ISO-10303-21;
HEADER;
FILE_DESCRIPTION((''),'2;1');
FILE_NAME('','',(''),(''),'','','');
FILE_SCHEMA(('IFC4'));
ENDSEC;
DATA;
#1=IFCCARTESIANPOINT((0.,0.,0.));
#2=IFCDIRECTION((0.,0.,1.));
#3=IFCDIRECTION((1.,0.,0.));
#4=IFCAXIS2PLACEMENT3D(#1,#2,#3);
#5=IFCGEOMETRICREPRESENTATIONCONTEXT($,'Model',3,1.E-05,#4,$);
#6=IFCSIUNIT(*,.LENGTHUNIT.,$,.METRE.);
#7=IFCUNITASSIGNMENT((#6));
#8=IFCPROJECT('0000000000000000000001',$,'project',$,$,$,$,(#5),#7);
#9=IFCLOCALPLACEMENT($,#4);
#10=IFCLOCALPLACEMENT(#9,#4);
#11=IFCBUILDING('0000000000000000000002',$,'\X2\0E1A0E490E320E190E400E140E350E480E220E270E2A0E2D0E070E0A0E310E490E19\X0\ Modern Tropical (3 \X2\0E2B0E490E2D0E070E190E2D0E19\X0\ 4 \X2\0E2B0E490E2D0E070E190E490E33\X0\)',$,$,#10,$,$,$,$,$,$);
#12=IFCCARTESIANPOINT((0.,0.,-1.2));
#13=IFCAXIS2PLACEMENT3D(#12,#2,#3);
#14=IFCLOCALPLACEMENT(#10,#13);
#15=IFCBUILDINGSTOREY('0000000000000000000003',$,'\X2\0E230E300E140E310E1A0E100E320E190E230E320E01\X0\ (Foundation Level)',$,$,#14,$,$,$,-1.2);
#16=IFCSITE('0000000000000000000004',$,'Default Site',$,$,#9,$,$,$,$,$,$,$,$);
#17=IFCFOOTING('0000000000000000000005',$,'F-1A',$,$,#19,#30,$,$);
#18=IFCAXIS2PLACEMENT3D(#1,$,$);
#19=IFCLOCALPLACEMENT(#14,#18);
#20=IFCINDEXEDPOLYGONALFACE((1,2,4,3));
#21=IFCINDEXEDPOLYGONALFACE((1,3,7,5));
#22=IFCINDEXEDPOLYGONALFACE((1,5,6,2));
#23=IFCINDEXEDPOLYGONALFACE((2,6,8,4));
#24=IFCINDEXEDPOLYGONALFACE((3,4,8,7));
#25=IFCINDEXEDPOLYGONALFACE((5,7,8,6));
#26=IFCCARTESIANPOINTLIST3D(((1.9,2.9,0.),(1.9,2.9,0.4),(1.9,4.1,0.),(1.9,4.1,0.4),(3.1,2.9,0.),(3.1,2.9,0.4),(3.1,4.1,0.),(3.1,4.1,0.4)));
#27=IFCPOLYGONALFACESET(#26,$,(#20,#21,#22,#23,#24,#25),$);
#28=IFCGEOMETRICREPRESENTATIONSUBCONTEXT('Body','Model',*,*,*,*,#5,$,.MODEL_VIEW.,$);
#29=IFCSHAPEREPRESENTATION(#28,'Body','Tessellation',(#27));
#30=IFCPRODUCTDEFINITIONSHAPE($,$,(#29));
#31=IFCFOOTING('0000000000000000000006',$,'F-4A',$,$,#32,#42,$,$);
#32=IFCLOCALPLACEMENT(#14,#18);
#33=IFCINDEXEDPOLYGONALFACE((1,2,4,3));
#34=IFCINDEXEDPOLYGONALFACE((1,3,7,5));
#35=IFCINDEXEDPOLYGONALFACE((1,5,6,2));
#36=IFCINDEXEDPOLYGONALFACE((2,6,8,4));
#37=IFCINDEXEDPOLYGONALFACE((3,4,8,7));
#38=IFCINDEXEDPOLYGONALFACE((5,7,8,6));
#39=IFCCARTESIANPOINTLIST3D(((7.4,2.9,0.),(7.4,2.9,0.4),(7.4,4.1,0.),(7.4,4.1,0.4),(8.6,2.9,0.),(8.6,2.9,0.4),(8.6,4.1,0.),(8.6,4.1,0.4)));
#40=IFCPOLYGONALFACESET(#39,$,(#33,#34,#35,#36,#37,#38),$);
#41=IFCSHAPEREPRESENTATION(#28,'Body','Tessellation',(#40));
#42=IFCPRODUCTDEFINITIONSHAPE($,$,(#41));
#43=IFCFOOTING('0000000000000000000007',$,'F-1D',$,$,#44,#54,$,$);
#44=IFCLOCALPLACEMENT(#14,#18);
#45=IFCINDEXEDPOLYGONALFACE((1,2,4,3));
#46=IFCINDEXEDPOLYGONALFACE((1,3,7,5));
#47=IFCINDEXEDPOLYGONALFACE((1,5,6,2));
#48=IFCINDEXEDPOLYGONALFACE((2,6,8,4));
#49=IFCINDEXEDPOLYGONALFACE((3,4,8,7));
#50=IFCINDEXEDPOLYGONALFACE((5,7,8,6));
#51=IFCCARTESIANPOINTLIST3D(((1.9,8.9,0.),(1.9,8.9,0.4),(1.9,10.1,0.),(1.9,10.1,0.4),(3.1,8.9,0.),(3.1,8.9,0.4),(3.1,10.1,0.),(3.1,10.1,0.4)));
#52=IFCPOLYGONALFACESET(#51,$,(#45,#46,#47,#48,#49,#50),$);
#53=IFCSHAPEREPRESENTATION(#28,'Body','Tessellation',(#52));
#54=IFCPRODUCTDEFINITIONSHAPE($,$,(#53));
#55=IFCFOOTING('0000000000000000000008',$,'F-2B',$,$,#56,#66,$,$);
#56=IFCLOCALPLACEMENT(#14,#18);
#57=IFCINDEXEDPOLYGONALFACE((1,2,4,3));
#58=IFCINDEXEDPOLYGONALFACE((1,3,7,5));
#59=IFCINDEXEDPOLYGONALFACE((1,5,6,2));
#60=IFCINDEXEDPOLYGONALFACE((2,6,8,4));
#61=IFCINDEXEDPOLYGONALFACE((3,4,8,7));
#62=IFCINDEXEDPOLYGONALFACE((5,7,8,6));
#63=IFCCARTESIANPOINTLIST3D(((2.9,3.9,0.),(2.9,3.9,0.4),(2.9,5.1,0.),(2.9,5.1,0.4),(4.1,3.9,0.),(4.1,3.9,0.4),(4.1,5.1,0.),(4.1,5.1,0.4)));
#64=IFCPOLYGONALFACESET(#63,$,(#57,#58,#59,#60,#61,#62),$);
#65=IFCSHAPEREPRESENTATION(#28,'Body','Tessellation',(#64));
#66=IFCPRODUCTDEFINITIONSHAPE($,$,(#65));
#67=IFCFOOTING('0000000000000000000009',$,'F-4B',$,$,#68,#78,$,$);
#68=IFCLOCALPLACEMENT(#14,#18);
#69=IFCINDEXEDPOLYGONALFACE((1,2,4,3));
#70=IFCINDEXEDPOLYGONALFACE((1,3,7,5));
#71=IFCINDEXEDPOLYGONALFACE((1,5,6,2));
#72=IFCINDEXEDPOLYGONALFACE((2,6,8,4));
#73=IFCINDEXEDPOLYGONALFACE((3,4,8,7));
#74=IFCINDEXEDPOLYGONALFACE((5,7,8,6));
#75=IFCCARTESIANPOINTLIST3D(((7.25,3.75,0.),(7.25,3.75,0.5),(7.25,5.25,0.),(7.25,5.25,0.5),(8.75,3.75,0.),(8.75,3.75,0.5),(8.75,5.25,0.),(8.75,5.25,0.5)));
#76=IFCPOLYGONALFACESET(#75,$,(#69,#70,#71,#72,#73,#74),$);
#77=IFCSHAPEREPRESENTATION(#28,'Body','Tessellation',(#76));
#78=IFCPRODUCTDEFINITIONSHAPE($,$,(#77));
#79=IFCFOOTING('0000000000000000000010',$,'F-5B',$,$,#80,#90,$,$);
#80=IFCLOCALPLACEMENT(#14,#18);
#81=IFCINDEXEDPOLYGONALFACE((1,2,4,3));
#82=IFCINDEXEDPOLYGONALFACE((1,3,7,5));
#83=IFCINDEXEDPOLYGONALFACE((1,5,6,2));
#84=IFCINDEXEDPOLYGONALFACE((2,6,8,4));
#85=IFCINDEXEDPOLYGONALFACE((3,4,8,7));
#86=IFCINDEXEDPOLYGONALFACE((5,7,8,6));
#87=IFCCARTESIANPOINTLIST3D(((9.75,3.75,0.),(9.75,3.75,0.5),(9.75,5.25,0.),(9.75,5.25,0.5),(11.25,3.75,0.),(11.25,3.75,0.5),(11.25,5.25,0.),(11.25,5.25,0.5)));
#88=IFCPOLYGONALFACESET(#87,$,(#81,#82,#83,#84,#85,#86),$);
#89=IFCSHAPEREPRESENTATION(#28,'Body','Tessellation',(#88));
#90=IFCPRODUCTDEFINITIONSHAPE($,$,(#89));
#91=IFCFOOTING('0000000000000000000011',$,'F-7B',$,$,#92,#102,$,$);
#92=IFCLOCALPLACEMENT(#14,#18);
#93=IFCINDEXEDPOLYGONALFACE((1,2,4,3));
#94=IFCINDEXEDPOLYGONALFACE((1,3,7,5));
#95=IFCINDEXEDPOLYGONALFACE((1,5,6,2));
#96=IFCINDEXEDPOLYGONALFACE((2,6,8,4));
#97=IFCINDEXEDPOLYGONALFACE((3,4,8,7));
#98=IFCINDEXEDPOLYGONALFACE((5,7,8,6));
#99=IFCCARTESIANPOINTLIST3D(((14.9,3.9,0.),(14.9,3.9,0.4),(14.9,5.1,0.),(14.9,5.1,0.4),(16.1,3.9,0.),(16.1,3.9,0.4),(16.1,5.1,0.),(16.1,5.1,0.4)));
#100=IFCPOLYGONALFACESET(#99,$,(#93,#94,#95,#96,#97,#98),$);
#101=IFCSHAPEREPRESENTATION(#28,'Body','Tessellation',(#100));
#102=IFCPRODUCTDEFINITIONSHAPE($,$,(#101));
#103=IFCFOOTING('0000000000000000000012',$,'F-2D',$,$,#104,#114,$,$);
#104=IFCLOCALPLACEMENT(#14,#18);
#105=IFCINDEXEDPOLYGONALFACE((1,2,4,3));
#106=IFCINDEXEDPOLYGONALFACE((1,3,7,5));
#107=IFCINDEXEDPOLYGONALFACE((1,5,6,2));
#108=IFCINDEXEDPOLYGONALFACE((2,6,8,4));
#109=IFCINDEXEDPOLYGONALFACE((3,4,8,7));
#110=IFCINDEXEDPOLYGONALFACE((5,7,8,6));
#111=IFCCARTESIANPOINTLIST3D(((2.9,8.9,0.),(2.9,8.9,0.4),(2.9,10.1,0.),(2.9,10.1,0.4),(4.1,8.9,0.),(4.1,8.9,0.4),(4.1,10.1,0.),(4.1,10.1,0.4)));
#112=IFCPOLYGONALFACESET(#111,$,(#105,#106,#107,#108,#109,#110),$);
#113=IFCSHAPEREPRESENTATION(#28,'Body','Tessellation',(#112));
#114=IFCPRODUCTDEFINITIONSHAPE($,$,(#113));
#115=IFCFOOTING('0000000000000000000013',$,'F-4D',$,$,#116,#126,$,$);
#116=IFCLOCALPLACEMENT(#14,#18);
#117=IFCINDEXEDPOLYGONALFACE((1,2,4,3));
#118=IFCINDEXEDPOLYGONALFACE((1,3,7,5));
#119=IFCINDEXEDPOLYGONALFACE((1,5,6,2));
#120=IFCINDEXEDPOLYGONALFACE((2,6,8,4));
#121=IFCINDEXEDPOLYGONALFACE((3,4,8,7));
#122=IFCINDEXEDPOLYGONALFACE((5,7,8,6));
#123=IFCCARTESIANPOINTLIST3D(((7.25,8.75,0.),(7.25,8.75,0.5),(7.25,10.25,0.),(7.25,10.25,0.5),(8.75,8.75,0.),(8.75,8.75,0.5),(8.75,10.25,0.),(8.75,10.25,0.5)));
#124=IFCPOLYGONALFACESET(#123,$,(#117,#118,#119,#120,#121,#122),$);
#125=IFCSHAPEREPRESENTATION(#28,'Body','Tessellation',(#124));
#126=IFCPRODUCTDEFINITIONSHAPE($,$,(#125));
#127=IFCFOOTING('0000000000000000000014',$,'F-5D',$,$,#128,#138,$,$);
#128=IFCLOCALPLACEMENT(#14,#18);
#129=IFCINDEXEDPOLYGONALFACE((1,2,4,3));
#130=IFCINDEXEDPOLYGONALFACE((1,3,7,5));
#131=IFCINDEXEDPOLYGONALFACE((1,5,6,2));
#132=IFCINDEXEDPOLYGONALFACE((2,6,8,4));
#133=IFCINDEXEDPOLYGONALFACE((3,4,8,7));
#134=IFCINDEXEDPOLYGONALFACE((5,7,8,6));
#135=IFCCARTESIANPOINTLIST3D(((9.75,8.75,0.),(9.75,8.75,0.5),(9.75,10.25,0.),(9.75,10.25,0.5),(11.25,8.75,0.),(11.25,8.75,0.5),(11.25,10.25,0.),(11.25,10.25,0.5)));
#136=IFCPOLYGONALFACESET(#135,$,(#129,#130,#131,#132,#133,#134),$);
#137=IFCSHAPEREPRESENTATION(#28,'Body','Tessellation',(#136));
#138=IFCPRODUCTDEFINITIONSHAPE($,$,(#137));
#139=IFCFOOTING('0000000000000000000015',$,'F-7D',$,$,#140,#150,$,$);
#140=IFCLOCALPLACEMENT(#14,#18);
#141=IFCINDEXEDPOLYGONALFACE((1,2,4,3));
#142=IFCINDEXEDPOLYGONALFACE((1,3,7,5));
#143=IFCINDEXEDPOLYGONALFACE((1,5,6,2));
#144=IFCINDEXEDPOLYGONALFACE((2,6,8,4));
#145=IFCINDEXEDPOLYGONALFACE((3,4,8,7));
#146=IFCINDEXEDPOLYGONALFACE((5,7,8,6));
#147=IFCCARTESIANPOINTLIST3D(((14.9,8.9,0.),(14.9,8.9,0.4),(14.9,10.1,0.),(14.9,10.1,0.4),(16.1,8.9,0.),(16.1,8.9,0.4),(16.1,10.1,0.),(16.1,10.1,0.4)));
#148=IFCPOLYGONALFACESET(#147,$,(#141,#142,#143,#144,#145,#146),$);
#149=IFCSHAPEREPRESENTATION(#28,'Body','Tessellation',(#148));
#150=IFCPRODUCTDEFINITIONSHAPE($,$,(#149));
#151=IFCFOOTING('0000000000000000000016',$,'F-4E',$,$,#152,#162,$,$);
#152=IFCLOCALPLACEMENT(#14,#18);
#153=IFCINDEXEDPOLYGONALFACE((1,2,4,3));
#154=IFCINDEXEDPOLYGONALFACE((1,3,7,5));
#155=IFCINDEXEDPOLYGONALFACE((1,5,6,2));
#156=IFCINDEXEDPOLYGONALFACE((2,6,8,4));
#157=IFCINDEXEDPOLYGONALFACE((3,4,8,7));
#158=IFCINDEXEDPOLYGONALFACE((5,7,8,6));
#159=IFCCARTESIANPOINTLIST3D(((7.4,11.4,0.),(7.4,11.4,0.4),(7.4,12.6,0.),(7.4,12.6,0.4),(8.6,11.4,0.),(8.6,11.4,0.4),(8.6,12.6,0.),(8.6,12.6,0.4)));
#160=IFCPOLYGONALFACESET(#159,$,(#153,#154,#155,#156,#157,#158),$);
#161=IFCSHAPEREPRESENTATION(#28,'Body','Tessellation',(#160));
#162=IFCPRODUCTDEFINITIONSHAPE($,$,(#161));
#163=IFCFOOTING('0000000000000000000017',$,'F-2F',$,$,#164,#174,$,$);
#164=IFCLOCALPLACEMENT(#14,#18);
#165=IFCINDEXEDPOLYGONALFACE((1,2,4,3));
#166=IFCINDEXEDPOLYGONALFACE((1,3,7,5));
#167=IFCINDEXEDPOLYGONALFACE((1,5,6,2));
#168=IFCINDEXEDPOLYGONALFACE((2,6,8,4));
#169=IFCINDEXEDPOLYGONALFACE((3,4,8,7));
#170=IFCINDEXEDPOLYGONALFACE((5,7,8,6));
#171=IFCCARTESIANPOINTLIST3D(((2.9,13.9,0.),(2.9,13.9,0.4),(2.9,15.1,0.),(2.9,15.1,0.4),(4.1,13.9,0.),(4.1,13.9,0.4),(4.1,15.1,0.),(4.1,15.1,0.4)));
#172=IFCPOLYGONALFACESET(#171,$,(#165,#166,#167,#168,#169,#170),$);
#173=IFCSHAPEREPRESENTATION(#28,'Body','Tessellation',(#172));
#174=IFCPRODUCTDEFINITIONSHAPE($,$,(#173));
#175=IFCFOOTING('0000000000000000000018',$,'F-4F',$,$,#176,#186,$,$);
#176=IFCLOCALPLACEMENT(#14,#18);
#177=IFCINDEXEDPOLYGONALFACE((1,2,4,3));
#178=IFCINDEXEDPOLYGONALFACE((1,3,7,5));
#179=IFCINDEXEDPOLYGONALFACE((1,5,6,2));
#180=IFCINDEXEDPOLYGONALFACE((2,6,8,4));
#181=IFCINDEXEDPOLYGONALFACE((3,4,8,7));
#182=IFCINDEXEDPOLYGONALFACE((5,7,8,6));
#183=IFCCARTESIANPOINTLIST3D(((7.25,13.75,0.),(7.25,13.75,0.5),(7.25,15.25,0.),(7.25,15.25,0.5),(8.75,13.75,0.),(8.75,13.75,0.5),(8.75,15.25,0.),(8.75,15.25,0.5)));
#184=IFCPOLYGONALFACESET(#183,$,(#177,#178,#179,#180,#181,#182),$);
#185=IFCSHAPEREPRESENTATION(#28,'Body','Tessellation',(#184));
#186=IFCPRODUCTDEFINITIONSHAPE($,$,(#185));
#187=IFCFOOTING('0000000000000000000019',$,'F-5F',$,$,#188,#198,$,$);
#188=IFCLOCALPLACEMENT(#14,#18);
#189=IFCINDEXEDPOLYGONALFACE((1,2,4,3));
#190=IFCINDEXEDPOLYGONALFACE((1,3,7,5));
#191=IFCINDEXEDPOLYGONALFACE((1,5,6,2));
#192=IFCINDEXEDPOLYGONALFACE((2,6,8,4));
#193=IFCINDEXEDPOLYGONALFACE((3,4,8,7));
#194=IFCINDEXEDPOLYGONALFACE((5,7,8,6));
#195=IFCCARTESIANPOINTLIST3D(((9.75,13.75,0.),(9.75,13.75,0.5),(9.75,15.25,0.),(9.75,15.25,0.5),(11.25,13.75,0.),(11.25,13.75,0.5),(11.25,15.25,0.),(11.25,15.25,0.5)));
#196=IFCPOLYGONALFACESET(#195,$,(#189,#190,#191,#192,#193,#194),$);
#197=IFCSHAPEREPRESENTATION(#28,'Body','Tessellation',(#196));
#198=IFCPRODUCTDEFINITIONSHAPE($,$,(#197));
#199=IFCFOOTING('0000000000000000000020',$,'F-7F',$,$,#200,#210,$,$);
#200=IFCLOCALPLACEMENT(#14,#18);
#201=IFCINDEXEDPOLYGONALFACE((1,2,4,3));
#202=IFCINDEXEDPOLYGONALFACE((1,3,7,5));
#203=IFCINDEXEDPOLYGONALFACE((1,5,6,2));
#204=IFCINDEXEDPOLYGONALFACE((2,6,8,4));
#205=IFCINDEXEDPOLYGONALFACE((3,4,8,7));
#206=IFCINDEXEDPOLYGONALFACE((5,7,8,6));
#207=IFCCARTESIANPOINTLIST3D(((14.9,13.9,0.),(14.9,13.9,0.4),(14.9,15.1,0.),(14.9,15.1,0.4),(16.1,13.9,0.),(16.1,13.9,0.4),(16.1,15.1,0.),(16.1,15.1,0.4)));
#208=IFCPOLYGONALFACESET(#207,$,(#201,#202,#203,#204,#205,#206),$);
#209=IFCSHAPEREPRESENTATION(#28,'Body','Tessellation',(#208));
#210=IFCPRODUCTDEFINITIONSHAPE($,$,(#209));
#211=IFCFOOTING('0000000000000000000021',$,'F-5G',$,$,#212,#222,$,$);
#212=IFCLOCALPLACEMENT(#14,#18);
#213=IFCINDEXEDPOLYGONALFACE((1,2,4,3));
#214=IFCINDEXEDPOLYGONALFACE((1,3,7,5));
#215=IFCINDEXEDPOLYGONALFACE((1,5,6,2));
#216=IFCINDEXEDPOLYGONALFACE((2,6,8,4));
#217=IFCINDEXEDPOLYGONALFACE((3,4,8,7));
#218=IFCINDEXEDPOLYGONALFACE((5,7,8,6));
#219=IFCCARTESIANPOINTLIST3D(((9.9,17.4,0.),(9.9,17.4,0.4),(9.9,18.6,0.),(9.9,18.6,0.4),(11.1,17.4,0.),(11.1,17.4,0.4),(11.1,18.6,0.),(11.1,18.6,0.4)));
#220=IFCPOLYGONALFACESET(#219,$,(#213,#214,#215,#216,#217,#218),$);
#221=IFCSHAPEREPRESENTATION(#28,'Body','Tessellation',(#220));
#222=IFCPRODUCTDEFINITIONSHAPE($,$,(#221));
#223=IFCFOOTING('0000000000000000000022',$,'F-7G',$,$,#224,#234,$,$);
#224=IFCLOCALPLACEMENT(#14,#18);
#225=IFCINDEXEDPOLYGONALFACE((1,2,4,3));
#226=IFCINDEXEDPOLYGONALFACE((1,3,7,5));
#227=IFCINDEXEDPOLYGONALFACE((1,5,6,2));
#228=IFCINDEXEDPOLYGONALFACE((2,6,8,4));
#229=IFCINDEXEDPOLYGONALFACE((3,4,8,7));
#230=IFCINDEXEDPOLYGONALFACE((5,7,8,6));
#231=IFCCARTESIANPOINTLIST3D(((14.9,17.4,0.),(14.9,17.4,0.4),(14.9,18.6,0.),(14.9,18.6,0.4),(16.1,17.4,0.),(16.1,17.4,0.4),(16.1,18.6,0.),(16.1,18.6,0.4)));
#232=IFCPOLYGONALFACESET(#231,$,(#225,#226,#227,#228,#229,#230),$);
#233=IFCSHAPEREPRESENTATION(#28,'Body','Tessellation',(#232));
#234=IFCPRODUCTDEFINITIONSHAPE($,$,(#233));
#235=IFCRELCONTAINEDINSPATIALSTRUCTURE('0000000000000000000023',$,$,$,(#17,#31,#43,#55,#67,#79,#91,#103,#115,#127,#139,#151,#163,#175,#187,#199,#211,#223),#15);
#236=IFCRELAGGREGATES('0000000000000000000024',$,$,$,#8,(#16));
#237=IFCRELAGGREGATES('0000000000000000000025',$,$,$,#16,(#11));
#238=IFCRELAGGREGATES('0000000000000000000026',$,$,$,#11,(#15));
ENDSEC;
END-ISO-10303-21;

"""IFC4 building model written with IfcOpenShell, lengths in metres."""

from ifc_helpers import new_model, si_unit, frame, origin_with_axes, origin_2d, place, context, subcontext, project, spatial, rectangle, extrude, element, save


model = new_model("IFC4")

# Units and contexts
model_context = context("Model", 3, precision=1e-05, world=origin_with_axes())
body_context = subcontext(model_context, "Body", "Model", "MODEL_VIEW")
ifc_project = project(units=[si_unit("LENGTHUNIT", "METRE")], contexts=[model_context])

# Site, building, storey
site_placement = place(None, origin_with_axes())
site = spatial("IfcSite", under=ifc_project, at=site_placement, Name="Default Site")
building_placement = place(site_placement, origin_with_axes())
building = spatial("IfcBuilding", under=site, at=building_placement, Name="บ้านเดี่ยวสองชั้น Modern Tropical (3 ห้องนอน 4 ห้องน้ำ)")
storey_placement = place(building_placement, frame((0.0, 0.0, -1.2), z_axis=(0.0, 0.0, 1.0), x_axis=(1.0, 0.0, 0.0)))
storey = spatial("IfcBuildingStorey", under=building, at=storey_placement, Name="ระดับฐานราก (Foundation Level)", Elevation=-1.2)

# Footings
for number, where, z_axis, x_axis, name in (
    (1, (2.5, 3.5, 0.0), (0.0, 0.0, 1.0), (1.0, 0.0, 0.0), "F-1A"),
    (2, (8.0, 3.5, 0.0), (0.0, 0.0, 1.0), (1.0, 0.0, 0.0), "F-4A"),
    (3, (2.5, 9.5, 0.0), (0.0, 0.0, 1.0), (1.0, 0.0, 0.0), "F-1D"),
    (4, (3.5, 4.5, 0.0), (0.0, 0.0, 1.0), (1.0, 0.0, 0.0), "F-2B"),
):
    element("IfcFooting", number, at=place(storey_placement, frame(where, z_axis=z_axis, x_axis=x_axis)), inside=storey, Name=name, context=body_context, shape_type="SweptSolid", body=[
        extrude(rectangle(XDim=1.2, YDim=1.2, at=origin_2d()), origin_with_axes(), (0.0, 0.0, 1.0), 0.4),
    ])
for number, where, z_axis, x_axis, name in (
    (5, (8.0, 4.5, 0.0), (0.0, 0.0, 1.0), (1.0, 0.0, 0.0), "F-4B"),
    (6, (10.5, 4.5, 0.0), (0.0, 0.0, 1.0), (1.0, 0.0, 0.0), "F-5B"),
):
    element("IfcFooting", number, at=place(storey_placement, frame(where, z_axis=z_axis, x_axis=x_axis)), inside=storey, Name=name, context=body_context, shape_type="SweptSolid", body=[
        extrude(rectangle(XDim=1.5, YDim=1.5, at=origin_2d()), origin_with_axes(), (0.0, 0.0, 1.0), 0.5),
    ])
for number, where, z_axis, x_axis, name in (
    (7, (15.5, 4.5, 0.0), (0.0, 0.0, 1.0), (1.0, 0.0, 0.0), "F-7B"),
    (8, (3.5, 9.5, 0.0), (0.0, 0.0, 1.0), (1.0, 0.0, 0.0), "F-2D"),
):
    element("IfcFooting", number, at=place(storey_placement, frame(where, z_axis=z_axis, x_axis=x_axis)), inside=storey, Name=name, context=body_context, shape_type="SweptSolid", body=[
        extrude(rectangle(XDim=1.2, YDim=1.2, at=origin_2d()), origin_with_axes(), (0.0, 0.0, 1.0), 0.4),
    ])
for number, where, z_axis, x_axis, name in (
    (9, (8.0, 9.5, 0.0), (0.0, 0.0, 1.0), (1.0, 0.0, 0.0), "F-4D"),
    (10, (10.5, 9.5, 0.0), (0.0, 0.0, 1.0), (1.0, 0.0, 0.0), "F-5D"),
):
    element("IfcFooting", number, at=place(storey_placement, frame(where, z_axis=z_axis, x_axis=x_axis)), inside=storey, Name=name, context=body_context, shape_type="SweptSolid", body=[
        extrude(rectangle(XDim=1.5, YDim=1.5, at=origin_2d()), origin_with_axes(), (0.0, 0.0, 1.0), 0.5),
    ])
for number, where, z_axis, x_axis, name in (
    (11, (15.5, 9.5, 0.0), (0.0, 0.0, 1.0), (1.0, 0.0, 0.0), "F-7D"),
    (12, (8.0, 12.0, 0.0), (0.0, 0.0, 1.0), (1.0, 0.0, 0.0), "F-4E"),
    (13, (3.5, 14.5, 0.0), (0.0, 0.0, 1.0), (1.0, 0.0, 0.0), "F-2F"),
):
    element("IfcFooting", number, at=place(storey_placement, frame(where, z_axis=z_axis, x_axis=x_axis)), inside=storey, Name=name, context=body_context, shape_type="SweptSolid", body=[
        extrude(rectangle(XDim=1.2, YDim=1.2, at=origin_2d()), origin_with_axes(), (0.0, 0.0, 1.0), 0.4),
    ])
for number, where, z_axis, x_axis, name in (
    (14, (8.0, 14.5, 0.0), (0.0, 0.0, 1.0), (1.0, 0.0, 0.0), "F-4F"),
    (15, (10.5, 14.5, 0.0), (0.0, 0.0, 1.0), (1.0, 0.0, 0.0), "F-5F"),
):
    element("IfcFooting", number, at=place(storey_placement, frame(where, z_axis=z_axis, x_axis=x_axis)), inside=storey, Name=name, context=body_context, shape_type="SweptSolid", body=[
        extrude(rectangle(XDim=1.5, YDim=1.5, at=origin_2d()), origin_with_axes(), (0.0, 0.0, 1.0), 0.5),
    ])
for number, where, z_axis, x_axis, name in (
    (16, (15.5, 14.5, 0.0), (0.0, 0.0, 1.0), (1.0, 0.0, 0.0), "F-7F"),
    (17, (10.5, 18.0, 0.0), (0.0, 0.0, 1.0), (1.0, 0.0, 0.0), "F-5G"),
    (18, (15.5, 18.0, 0.0), (0.0, 0.0, 1.0), (1.0, 0.0, 0.0), "F-7G"),
):
    element("IfcFooting", number, at=place(storey_placement, frame(where, z_axis=z_axis, x_axis=x_axis)), inside=storey, Name=name, context=body_context, shape_type="SweptSolid", body=[
        extrude(rectangle(XDim=1.2, YDim=1.2, at=origin_2d()), origin_with_axes(), (0.0, 0.0, 1.0), 0.4),
    ])

save(model, "model.ifc")
